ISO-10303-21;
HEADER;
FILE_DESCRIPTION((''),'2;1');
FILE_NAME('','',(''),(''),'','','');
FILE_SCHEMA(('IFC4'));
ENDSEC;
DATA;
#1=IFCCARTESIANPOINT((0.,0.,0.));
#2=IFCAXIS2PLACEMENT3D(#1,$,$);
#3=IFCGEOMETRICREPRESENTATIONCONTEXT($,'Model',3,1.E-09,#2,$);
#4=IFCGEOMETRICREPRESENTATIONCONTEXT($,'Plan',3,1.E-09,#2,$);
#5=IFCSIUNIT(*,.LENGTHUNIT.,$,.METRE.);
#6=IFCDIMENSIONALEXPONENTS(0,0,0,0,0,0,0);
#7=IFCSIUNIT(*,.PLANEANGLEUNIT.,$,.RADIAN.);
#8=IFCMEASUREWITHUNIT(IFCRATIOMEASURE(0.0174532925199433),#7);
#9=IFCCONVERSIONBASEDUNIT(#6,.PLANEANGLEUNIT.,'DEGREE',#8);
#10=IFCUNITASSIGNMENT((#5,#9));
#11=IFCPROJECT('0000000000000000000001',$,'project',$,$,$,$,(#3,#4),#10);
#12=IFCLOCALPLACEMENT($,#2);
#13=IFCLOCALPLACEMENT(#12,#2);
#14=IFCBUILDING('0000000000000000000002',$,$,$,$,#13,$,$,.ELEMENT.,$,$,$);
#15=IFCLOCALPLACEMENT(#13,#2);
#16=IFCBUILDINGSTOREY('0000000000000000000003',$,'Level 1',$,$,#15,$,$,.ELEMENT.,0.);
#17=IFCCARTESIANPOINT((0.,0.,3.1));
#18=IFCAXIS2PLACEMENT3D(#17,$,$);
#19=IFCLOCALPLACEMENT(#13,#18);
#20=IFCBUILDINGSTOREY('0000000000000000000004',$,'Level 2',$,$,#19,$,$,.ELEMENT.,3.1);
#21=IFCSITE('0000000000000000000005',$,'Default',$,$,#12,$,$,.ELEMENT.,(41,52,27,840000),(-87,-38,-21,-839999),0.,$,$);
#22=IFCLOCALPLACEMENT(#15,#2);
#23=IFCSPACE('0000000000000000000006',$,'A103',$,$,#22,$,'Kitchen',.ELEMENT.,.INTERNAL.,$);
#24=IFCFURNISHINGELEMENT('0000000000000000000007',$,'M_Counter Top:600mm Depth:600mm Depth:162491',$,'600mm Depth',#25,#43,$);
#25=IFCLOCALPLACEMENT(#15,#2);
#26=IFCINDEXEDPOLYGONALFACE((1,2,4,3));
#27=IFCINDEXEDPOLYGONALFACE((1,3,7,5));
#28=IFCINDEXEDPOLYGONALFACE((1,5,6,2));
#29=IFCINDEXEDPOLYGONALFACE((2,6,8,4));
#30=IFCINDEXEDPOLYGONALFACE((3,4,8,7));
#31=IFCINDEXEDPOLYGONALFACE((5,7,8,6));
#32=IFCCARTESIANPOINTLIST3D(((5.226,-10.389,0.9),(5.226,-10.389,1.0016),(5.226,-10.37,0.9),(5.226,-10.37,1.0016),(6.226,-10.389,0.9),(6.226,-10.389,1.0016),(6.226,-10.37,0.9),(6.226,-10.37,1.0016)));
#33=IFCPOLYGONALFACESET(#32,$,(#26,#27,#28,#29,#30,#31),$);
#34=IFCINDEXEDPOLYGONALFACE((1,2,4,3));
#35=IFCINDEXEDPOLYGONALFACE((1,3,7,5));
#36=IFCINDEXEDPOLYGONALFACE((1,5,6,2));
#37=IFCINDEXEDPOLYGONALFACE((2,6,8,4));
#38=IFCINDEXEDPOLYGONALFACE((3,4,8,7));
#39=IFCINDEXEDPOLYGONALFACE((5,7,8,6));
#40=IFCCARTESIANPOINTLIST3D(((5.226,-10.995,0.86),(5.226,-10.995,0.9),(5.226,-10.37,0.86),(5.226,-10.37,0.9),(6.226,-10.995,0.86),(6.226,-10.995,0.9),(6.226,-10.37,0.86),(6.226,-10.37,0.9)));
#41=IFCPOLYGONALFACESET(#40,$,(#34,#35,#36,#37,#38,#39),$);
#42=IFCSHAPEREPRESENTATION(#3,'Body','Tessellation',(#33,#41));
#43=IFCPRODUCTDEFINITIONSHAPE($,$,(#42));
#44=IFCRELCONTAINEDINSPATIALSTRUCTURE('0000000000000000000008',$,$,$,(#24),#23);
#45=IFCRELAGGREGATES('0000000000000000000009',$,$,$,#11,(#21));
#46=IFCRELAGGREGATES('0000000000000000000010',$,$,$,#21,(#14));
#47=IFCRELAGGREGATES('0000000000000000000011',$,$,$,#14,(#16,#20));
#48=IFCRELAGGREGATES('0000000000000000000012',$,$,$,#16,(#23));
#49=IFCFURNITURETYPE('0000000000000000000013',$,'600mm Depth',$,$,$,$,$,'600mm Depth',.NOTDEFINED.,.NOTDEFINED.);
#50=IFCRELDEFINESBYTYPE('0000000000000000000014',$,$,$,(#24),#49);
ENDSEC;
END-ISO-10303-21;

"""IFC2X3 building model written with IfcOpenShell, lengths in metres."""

from ifc_helpers import new_model, entity, si_unit, converted_unit, frame, origin, origin_2d_with_axis, place, context, project, spatial, rectangle, extrude, source, transform, mapped, type_object, type_shapes, element, save


model = new_model("IFC2X3")

# Units and contexts
model_context = context("Model", 3, precision=1e-09, world=origin())
plan_context = context("Plan", 3, precision=1e-09, world=origin())
ifc_project = project(units=[si_unit("LENGTHUNIT", "METRE"), converted_unit("PLANEANGLEUNIT", "DEGREE", entity("IfcRatioMeasure", 0.0174532925199433), si_unit("PLANEANGLEUNIT", "RADIAN"), dimensions=[0, 0, 0, 0, 0, 0, 0])], contexts=[model_context, plan_context])

# Site, building, storey
site_placement = place(None, origin())
site = spatial("IfcSite", under=ifc_project, at=site_placement, Name="Default", CompositionType="ELEMENT", RefLatitude=(41, 52, 27, 840000), RefLongitude=(-87, -38, -21, -839999), RefElevation=0.0)
building_placement = place(site_placement, origin())
building = spatial("IfcBuilding", under=site, at=building_placement, CompositionType="ELEMENT")
storey_1_placement = place(building_placement, origin())
storey_1 = spatial("IfcBuildingStorey", under=building, at=storey_1_placement, Name="Level 1", CompositionType="ELEMENT", Elevation=0.0)

# Shared definitions
storey_2_placement = place(building_placement, frame((0.0, 0.0, 3.1)))
storey_2 = spatial("IfcBuildingStorey", under=building, at=storey_2_placement, Name="Level 2", CompositionType="ELEMENT", Elevation=3.1)

# Shared definitions
space_1_placement = place(storey_1_placement, origin())
space_1 = spatial("IfcSpace", under=storey_1, at=space_1_placement, Name="A103", LongName="Kitchen", CompositionType="ELEMENT", InteriorOrExteriorSpace="INTERNAL")

# Furnishing element
furniture_type_1 = type_object("IfcFurnitureType", Name="600mm Depth", ElementType="600mm Depth", AssemblyPlace="NOTDEFINED")
shared_shape_1 = source(origin(), model_context, "Body", "SweptSolid", [
    extrude(rectangle(XDim=0.0191, YDim=1.0, at=origin_2d_with_axis()), frame((-0.7005, -0.0095, 0.9), z_axis=(0.0, 0.0, 1.0), x_axis=(0.0, -1.0, 0.0)), (0.0, 0.0, 1.0), 0.1016),
    extrude(rectangle(XDim=1.0, YDim=0.625, at=origin_2d_with_axis()), frame((-0.7005, -0.3125, 0.86), z_axis=(0.0, 0.0, 1.0), x_axis=(-1.0, 0.0, 0.0)), (0.0, 0.0, 1.0), 0.04),
])
type_shapes(furniture_type_1, [shared_shape_1])
furnishing_1_placement = place(space_1_placement, frame((6.4265, -10.37, 0.0)))
element("IfcFurnishingElement", 1, at=furnishing_1_placement, inside=space_1, type_object=furniture_type_1, Name="M_Counter Top:600mm Depth:600mm Depth:162491", ObjectType="600mm Depth", context=model_context, shape_type="MappedRepresentation", body=[
    mapped(shared_shape_1, transform((0.0, 0.0, 0.0), scale=1.0)),
])

save(model, "model.ifc")
